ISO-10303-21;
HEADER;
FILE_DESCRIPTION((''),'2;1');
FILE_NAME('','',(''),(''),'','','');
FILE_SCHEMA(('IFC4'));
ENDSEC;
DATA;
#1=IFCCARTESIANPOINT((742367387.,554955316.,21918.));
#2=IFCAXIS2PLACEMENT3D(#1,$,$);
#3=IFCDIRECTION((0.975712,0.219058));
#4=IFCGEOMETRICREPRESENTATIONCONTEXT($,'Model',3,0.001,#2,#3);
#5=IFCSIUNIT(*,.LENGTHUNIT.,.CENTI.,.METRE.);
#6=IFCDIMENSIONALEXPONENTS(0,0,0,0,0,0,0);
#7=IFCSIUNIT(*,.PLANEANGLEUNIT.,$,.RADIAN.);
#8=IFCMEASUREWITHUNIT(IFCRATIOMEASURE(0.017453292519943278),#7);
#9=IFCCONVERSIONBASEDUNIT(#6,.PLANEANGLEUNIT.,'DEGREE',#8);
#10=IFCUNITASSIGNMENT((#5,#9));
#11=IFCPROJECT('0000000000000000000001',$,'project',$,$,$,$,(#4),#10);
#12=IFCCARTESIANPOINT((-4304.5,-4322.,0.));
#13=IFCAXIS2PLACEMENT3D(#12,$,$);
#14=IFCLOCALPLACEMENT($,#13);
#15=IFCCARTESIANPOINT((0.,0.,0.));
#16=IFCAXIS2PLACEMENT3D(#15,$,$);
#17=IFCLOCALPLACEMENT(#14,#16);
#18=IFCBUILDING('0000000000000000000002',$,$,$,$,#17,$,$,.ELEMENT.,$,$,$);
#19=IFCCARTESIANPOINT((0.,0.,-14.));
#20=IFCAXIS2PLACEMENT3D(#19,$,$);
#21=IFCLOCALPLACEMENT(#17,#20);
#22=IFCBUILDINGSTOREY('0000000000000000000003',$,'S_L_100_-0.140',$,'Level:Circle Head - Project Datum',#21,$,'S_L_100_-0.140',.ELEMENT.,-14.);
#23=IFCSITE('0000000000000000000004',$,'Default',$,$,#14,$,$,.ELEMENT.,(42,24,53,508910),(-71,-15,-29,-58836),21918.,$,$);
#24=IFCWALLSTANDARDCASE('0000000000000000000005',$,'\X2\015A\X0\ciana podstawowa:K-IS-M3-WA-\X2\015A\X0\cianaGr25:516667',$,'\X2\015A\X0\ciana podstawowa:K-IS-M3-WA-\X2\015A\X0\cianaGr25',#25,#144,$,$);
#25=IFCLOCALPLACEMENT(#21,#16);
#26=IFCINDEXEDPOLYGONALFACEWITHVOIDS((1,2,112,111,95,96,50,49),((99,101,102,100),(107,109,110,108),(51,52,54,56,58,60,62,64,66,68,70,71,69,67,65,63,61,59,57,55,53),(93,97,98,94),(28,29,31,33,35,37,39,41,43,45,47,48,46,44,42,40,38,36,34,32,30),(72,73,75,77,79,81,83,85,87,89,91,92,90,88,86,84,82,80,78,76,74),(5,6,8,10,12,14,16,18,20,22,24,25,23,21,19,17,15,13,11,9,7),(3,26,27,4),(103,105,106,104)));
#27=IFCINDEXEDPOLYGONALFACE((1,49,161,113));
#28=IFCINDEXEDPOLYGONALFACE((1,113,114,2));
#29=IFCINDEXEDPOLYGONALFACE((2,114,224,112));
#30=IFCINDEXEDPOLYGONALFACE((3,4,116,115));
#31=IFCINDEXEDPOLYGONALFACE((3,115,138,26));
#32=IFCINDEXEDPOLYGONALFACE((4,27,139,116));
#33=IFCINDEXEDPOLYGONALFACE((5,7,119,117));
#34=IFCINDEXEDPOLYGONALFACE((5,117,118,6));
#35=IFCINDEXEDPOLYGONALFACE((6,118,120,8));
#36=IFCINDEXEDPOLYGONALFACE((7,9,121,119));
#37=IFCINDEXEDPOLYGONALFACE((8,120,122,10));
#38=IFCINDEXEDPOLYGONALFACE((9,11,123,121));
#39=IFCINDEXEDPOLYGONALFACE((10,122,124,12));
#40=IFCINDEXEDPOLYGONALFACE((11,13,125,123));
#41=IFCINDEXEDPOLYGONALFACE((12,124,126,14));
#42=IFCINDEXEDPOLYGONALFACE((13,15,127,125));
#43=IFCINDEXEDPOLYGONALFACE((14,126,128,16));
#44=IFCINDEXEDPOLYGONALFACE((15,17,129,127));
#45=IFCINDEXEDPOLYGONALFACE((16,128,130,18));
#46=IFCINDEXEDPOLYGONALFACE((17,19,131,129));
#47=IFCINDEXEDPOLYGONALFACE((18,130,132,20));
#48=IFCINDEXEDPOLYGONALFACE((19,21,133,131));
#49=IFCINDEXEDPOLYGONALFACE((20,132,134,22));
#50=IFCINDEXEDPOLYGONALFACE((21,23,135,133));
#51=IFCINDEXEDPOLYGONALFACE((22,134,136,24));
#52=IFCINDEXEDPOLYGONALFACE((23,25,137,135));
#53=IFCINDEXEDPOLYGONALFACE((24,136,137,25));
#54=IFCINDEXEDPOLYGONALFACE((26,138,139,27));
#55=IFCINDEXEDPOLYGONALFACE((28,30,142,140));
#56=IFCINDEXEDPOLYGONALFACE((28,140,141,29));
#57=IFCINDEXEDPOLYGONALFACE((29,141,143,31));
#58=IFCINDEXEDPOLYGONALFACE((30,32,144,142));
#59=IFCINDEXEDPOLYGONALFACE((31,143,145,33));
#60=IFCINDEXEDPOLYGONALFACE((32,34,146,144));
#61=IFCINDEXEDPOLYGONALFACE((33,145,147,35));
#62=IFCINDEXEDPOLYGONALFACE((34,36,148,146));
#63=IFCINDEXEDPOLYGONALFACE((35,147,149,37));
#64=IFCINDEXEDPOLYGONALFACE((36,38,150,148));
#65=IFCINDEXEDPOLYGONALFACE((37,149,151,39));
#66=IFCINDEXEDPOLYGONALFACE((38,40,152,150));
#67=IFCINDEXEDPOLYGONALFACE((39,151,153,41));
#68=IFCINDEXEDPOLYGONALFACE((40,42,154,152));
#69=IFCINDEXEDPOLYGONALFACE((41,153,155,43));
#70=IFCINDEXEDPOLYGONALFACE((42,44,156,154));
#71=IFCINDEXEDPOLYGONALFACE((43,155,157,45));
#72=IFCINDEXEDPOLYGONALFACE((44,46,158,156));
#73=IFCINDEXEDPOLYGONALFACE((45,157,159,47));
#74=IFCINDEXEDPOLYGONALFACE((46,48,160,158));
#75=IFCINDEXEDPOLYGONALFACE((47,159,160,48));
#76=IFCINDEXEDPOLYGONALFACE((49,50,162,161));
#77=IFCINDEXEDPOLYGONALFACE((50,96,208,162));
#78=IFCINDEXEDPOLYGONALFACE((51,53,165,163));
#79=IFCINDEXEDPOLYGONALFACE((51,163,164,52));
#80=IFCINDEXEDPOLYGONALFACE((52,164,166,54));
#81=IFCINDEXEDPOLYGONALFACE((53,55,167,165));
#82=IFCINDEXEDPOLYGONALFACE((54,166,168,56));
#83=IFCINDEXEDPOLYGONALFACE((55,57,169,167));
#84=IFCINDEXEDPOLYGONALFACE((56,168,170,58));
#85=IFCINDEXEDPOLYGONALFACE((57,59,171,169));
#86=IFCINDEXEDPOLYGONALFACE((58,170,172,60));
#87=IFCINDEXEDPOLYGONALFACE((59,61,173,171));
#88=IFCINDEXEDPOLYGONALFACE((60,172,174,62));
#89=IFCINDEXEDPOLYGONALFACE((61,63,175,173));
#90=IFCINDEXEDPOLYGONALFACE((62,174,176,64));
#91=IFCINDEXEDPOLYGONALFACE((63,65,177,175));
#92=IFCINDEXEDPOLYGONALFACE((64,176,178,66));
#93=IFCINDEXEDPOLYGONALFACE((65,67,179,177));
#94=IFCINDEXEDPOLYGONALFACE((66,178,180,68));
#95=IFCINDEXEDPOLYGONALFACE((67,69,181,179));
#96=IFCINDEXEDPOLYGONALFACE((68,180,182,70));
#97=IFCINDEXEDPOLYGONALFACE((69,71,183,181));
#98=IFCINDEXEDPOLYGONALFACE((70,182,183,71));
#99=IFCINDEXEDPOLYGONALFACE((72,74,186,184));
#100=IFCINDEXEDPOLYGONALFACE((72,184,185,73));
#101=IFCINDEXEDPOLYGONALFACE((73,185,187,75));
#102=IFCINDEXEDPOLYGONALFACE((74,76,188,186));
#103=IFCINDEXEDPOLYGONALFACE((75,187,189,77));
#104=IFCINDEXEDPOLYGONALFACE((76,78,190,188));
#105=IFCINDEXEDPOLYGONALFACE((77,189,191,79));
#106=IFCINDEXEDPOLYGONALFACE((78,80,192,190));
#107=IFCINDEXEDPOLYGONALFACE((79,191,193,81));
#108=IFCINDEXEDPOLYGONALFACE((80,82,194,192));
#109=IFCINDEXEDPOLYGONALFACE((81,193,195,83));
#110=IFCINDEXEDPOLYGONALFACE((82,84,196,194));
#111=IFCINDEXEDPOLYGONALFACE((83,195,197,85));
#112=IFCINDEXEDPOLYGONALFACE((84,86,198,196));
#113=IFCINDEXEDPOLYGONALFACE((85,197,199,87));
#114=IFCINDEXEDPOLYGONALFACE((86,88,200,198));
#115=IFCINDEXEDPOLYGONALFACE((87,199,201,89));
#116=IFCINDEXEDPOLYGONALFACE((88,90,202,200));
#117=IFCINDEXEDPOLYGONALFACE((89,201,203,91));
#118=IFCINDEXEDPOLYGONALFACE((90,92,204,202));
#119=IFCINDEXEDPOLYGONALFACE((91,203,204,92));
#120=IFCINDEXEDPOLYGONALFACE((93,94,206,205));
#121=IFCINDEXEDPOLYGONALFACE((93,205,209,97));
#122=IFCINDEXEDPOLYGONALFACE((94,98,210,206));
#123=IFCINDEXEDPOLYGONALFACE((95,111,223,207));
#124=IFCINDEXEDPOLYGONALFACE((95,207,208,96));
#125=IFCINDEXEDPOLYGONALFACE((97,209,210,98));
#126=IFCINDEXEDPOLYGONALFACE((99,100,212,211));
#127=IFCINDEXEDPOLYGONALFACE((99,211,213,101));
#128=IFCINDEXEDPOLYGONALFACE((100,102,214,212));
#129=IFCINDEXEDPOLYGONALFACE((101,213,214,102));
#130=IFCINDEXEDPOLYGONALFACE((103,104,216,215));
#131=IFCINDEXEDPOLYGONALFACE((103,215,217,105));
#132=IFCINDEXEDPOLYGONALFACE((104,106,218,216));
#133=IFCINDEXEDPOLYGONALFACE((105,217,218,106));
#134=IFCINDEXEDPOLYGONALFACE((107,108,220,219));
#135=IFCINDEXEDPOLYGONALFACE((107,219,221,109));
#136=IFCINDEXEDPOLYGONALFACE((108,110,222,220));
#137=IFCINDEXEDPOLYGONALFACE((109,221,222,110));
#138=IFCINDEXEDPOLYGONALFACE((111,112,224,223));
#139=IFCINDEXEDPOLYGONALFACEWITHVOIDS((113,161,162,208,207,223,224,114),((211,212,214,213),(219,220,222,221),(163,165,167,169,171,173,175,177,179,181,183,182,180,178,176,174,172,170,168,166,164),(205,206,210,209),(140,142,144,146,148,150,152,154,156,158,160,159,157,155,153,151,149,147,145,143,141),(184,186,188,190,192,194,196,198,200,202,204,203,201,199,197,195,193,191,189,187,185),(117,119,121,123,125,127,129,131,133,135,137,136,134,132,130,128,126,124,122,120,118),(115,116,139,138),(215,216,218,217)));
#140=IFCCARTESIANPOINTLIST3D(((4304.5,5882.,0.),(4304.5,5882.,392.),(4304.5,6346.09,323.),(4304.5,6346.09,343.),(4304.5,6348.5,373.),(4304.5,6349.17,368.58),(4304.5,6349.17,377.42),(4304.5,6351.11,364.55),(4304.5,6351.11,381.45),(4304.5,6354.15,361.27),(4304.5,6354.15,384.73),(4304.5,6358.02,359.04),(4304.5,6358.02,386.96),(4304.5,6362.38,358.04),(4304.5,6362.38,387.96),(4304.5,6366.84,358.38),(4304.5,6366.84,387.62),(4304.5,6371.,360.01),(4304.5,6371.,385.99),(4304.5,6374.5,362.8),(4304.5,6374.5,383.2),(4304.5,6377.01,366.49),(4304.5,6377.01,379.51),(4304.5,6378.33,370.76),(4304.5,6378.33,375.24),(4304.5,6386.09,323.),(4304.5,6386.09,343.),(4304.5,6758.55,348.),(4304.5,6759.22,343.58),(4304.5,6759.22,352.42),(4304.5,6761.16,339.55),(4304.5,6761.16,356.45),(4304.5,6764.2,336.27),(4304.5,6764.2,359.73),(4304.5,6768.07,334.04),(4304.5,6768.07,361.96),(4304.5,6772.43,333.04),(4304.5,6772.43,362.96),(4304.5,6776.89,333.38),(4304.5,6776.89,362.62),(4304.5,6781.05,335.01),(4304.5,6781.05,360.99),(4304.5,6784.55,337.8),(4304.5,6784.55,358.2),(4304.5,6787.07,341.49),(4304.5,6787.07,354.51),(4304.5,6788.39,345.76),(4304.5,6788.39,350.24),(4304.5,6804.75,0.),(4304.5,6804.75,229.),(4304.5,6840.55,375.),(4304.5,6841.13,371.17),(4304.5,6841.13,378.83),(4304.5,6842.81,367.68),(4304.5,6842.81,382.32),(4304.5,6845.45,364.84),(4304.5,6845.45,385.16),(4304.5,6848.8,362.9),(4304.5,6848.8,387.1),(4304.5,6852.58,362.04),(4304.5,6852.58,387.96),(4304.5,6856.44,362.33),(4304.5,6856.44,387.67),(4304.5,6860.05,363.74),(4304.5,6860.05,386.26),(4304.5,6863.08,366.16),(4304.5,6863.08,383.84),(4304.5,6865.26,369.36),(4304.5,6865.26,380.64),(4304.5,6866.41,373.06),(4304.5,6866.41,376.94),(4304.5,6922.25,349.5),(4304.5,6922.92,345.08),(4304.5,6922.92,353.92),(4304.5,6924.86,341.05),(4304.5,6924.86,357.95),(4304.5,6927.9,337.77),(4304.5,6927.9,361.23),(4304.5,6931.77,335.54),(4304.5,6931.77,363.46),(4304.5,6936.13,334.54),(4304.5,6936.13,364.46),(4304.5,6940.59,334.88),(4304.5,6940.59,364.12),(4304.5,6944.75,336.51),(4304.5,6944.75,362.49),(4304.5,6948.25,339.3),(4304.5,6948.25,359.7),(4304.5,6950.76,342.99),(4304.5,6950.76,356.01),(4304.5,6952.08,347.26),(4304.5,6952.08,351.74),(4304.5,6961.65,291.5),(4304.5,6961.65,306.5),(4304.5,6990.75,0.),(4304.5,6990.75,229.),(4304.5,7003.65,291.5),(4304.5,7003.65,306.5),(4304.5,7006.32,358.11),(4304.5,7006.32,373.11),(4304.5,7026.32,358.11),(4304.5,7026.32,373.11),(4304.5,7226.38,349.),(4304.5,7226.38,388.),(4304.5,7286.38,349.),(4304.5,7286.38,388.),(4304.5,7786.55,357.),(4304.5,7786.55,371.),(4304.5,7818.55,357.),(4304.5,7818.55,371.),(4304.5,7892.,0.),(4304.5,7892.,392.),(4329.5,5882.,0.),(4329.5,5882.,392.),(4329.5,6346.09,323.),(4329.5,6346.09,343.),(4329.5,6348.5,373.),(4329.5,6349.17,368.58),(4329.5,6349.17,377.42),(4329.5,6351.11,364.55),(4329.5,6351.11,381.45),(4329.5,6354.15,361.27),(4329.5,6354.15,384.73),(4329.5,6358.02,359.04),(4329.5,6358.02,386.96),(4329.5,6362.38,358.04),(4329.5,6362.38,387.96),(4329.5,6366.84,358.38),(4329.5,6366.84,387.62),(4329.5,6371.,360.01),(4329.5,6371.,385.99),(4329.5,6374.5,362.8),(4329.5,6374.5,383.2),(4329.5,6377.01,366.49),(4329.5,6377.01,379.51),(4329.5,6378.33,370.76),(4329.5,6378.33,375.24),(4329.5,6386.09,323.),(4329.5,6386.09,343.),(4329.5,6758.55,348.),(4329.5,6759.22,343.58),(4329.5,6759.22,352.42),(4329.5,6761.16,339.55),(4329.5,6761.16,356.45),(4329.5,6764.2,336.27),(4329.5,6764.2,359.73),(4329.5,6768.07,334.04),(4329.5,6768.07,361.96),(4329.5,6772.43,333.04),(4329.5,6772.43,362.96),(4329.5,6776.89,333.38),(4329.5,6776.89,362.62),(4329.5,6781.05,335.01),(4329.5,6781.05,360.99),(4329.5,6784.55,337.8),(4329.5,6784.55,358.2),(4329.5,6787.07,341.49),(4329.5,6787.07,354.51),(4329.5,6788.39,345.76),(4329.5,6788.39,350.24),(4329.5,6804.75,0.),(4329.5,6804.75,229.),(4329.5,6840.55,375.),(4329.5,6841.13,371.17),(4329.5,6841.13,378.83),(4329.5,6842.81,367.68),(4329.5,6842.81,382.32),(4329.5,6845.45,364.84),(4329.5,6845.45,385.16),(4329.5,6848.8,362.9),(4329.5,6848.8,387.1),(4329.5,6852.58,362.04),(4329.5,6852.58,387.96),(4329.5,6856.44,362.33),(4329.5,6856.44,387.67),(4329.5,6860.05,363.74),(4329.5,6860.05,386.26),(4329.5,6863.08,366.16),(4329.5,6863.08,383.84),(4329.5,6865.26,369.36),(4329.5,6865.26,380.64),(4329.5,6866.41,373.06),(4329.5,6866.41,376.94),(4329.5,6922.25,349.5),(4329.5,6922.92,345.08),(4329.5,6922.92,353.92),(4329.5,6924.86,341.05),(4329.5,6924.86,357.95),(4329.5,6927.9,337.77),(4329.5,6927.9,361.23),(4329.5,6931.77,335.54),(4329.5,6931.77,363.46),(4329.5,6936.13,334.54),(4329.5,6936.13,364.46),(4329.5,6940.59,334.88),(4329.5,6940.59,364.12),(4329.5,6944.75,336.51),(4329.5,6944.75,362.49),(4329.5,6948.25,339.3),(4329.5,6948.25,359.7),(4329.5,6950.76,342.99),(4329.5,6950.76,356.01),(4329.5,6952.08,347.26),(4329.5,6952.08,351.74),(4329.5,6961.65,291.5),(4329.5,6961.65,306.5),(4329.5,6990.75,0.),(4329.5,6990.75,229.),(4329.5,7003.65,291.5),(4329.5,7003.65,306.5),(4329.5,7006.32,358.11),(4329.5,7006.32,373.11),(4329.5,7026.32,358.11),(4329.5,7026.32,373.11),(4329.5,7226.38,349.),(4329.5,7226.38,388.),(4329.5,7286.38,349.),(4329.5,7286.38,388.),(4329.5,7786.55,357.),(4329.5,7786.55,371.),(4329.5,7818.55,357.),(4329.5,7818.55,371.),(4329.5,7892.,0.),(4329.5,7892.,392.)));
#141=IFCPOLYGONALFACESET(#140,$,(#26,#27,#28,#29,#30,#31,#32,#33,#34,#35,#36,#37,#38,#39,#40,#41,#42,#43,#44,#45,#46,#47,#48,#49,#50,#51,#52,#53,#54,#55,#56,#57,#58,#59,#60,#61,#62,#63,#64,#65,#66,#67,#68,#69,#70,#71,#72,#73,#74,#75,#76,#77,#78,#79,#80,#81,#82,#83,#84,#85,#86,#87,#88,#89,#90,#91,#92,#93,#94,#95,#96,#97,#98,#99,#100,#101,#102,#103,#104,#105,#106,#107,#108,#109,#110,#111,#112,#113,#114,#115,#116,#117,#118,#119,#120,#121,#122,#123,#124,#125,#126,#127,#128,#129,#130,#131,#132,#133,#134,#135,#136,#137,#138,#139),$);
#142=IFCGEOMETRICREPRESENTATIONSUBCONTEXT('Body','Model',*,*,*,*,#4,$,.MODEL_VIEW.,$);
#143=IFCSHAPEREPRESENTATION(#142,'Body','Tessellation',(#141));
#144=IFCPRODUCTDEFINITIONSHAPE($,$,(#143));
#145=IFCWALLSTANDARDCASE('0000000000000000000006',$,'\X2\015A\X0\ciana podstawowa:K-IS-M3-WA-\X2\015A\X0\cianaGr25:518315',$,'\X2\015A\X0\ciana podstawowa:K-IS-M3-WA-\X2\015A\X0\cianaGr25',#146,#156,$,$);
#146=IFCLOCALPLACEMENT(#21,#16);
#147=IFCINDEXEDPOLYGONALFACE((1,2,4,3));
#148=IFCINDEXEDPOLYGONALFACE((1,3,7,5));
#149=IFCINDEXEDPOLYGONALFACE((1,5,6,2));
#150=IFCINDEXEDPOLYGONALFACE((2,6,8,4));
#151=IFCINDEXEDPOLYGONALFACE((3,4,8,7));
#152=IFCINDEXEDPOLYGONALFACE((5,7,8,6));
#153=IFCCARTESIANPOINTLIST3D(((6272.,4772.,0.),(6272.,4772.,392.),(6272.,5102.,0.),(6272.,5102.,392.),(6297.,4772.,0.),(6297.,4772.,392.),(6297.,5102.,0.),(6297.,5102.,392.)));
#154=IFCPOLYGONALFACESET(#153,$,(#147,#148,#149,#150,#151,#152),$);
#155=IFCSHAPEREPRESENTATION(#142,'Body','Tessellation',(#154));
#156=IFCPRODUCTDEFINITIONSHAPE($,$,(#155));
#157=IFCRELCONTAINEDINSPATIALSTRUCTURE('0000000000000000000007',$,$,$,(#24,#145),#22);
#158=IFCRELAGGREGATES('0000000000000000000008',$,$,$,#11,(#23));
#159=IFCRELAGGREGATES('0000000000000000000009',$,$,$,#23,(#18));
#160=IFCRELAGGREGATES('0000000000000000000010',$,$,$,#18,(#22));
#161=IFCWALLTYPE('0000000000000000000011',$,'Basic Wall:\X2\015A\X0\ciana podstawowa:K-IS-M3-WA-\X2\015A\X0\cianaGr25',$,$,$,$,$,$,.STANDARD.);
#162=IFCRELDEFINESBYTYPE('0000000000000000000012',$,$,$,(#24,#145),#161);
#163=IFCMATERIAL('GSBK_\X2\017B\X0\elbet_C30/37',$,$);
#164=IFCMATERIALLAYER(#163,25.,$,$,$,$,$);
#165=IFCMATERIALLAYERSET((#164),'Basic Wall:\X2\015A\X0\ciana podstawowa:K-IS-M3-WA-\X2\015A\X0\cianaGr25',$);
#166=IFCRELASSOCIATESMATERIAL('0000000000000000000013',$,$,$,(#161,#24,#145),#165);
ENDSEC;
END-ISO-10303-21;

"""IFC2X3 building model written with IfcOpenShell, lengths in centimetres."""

from ifc_helpers import new_model, entity, si_unit, converted_unit, direction, frame, frame_2d, origin, origin_2d_with_axis, place, context, subcontext, project, spatial, rectangle, circle, extrude, material, layer, layer_set, layer_usage, type_object, element, save


model = new_model("IFC2X3")

# Units and contexts
model_context = context("Model", 3, precision=0.001, world=frame((742367387.0, 554955316.0, 21918.0)), true_north=direction((0.975712, 0.219058)))
body_context = subcontext(model_context, "Body", "Model", "MODEL_VIEW")
ifc_project = project(units=[si_unit("LENGTHUNIT", "METRE", prefix="CENTI"), converted_unit("PLANEANGLEUNIT", "DEGREE", entity("IfcRatioMeasure", 0.017453292519943278), si_unit("PLANEANGLEUNIT", "RADIAN"), dimensions=[0, 0, 0, 0, 0, 0, 0])], contexts=[model_context])

# Site, building, storey
site_placement = place(None, frame((-4304.5, -4322.0, 0.0)))
site = spatial("IfcSite", under=ifc_project, at=site_placement, Name="Default", CompositionType="ELEMENT", RefLatitude=(42, 24, 53, 508910), RefLongitude=(-71, -15, -29, -58836), RefElevation=21918.0)
building_placement = place(site_placement, origin())
building = spatial("IfcBuilding", under=site, at=building_placement, CompositionType="ELEMENT")
storey_placement = place(building_placement, frame((0.0, 0.0, -14.0)))
storey = spatial("IfcBuildingStorey", under=building, at=storey_placement, Name="S_L_100_-0.140", ObjectType="Level:Circle Head - Project Datum", LongName="S_L_100_-0.140", CompositionType="ELEMENT", Elevation=-14.0)

# Wall, openings
ifc_material_1 = material(Name="GSBK_Żelbet_C30/37")
ifc_layer_1 = layer(ifc_material_1, 25.0)
ifc_layer_set_1 = layer_set([ifc_layer_1], Name="Basic Wall:Ściana podstawowa:K-IS-M3-WA-ŚcianaGr25")
ifc_layer_usage_1 = layer_usage(ifc_layer_set_1, "AXIS2", "NEGATIVE", 12.5)
wall_type_1 = type_object("IfcWallType", Name="Basic Wall:Ściana podstawowa:K-IS-M3-WA-ŚcianaGr25", PredefinedType="STANDARD", material=ifc_layer_set_1)
wall_1_placement = place(storey_placement, frame((4317.0, 5882.0, 0.0), z_axis=(0.0, 0.0, 1.0), x_axis=(0.0, 1.0, 0.0)))
wall_1 = element("IfcWallStandardCase", 1, at=wall_1_placement, inside=storey, type_object=wall_type_1, material=ifc_layer_usage_1, Name="Ściana podstawowa:K-IS-M3-WA-ŚcianaGr25:516667", ObjectType="Ściana podstawowa:K-IS-M3-WA-ŚcianaGr25", context=body_context, shape_type="SweptSolid", body=[
    extrude(rectangle(XDim=2010.0, YDim=25.0, at=frame_2d((1005.0, 0.0), x_axis=(-1.0, 0.0))), origin(), (0.0, 0.0, 1.0), 392.0),
])
opening_1_placement = place(wall_1_placement, frame((922.75, 12.5, 0.0)))
element("IfcOpeningElement", 2, at=opening_1_placement, cuts=wall_1, ObjectType="Opening", context=body_context, shape_type="SweptSolid", body=[
    extrude(rectangle(XDim=229.0, YDim=186.0, at=frame_2d((0.0, 0.0), x_axis=(1.0, 0.0))), frame((93.0, -25.0, 114.5), z_axis=(0.0, 1.0, 0.0), x_axis=(0.0, 0.0, -1.0)), (0.0, 0.0, 1.0), 25.0),
])
opening_2_placement = place(wall_1_placement, frame((1344.38, 12.5, 349.0)))
element("IfcOpeningElement", 3, at=opening_2_placement, cuts=wall_1, ObjectType="Opening", context=body_context, shape_type="SweptSolid", body=[
    extrude(rectangle(XDim=39.0, YDim=60.0, at=frame_2d((0.0, 0.0), x_axis=(1.0, 0.0))), frame((30.0, -25.0, 19.5), z_axis=(0.0, 1.0, 0.0), x_axis=(0.0, 0.0, -1.0)), (0.0, 0.0, 1.0), 25.0),
])
opening_3_placement = place(wall_1_placement, frame((464.09, 12.5, 323.0)))
element("IfcOpeningElement", 4, at=opening_3_placement, cuts=wall_1, ObjectType="Opening", context=body_context, shape_type="SweptSolid", body=[
    extrude(rectangle(XDim=20.0, YDim=40.0, at=frame_2d((0.0, 0.0), x_axis=(1.0, 0.0))), frame((20.0, -25.0, 10.0), z_axis=(0.0, 1.0, 0.0), x_axis=(0.0, 0.0, -1.0)), (0.0, 0.0, 1.0), 25.0),
])
opening_4_placement = place(wall_1_placement, frame((1079.65, 12.5, 291.5)))
element("IfcOpeningElement", 5, at=opening_4_placement, cuts=wall_1, ObjectType="Opening", context=body_context, shape_type="SweptSolid", body=[
    extrude(rectangle(XDim=15.0, YDim=42.0, at=frame_2d((0.0, 0.0), x_axis=(1.0, 0.0))), frame((21.0, -25.0, 7.5), z_axis=(0.0, 1.0, 0.0), x_axis=(0.0, 0.0, -1.0)), (0.0, 0.0, 1.0), 25.0),
])
opening_5_placement = place(wall_1_placement, frame((1904.55, 12.5, 357.0)))
element("IfcOpeningElement", 6, at=opening_5_placement, cuts=wall_1, ObjectType="Opening", context=body_context, shape_type="SweptSolid", body=[
    extrude(rectangle(XDim=14.0, YDim=32.0, at=frame_2d((0.0, 0.0), x_axis=(1.0, 0.0))), frame((16.0, -25.0, 7.0), z_axis=(0.0, 1.0, 0.0), x_axis=(0.0, 0.0, -1.0)), (0.0, 0.0, 1.0), 25.0),
])
opening_6_placement = place(wall_1_placement, frame((1124.32, 12.5, 358.11)))
element("IfcOpeningElement", 7, at=opening_6_placement, cuts=wall_1, ObjectType="Opening", context=body_context, shape_type="SweptSolid", body=[
    extrude(rectangle(XDim=15.0, YDim=20.0, at=frame_2d((0.0, 0.0), x_axis=(1.0, 0.0))), frame((10.0, -25.0, 7.5), z_axis=(0.0, 1.0, 0.0), x_axis=(0.0, 0.0, -1.0)), (0.0, 0.0, 1.0), 25.0),
])
opening_7_placement = place(wall_1_placement, frame((466.34, 164.9, 332.84)))
element("IfcOpeningElement", 8, at=opening_7_placement, cuts=wall_1, ObjectType="Opening", context=body_context, shape_type="SweptSolid", body=[
    extrude(circle(Radius=15.0, at=origin_2d_with_axis()), frame((588.91, -304.8, 16.66), z_axis=(0.0, 1.0, 0.0), x_axis=(-1.0, 0.0, 0.0)), (0.0, 0.0, 1.0), 304.8),
    extrude(circle(Radius=15.0, at=origin_2d_with_axis()), frame((425.21, -304.8, 15.16), z_axis=(0.0, 1.0, 0.0), x_axis=(-1.0, 0.0, 0.0)), (0.0, 0.0, 1.0), 304.8),
    extrude(circle(Radius=13.0, at=origin_2d_with_axis()), frame((505.21, -304.8, 42.16), z_axis=(0.0, 1.0, 0.0), x_axis=(-1.0, 0.0, 0.0)), (0.0, 0.0, 1.0), 304.8),
    extrude(circle(Radius=15.0, at=frame_2d((0.0, 0.0), x_axis=(1.0, 0.0))), frame((15.16, -304.8, 40.16), z_axis=(0.0, 1.0, 0.0), x_axis=(-1.0, 0.0, 0.0)), (0.0, 0.0, 1.0), 304.8),
])

# Wall
ifc_layer_usage_2 = layer_usage(ifc_layer_set_1, "AXIS2", "NEGATIVE", 12.5)
wall_2_placement = place(storey_placement, frame((6284.5, 5102.0, 0.0), z_axis=(0.0, 0.0, 1.0), x_axis=(0.0, -1.0, 0.0)))
element("IfcWallStandardCase", 9, at=wall_2_placement, inside=storey, type_object=wall_type_1, material=ifc_layer_usage_2, Name="Ściana podstawowa:K-IS-M3-WA-ŚcianaGr25:518315", ObjectType="Ściana podstawowa:K-IS-M3-WA-ŚcianaGr25", context=body_context, shape_type="SweptSolid", body=[
    extrude(rectangle(XDim=330.0, YDim=25.0, at=frame_2d((165.0, 0.0), x_axis=(-1.0, 0.0))), origin(), (0.0, 0.0, 1.0), 392.0),
])

save(model, "model.ifc")
